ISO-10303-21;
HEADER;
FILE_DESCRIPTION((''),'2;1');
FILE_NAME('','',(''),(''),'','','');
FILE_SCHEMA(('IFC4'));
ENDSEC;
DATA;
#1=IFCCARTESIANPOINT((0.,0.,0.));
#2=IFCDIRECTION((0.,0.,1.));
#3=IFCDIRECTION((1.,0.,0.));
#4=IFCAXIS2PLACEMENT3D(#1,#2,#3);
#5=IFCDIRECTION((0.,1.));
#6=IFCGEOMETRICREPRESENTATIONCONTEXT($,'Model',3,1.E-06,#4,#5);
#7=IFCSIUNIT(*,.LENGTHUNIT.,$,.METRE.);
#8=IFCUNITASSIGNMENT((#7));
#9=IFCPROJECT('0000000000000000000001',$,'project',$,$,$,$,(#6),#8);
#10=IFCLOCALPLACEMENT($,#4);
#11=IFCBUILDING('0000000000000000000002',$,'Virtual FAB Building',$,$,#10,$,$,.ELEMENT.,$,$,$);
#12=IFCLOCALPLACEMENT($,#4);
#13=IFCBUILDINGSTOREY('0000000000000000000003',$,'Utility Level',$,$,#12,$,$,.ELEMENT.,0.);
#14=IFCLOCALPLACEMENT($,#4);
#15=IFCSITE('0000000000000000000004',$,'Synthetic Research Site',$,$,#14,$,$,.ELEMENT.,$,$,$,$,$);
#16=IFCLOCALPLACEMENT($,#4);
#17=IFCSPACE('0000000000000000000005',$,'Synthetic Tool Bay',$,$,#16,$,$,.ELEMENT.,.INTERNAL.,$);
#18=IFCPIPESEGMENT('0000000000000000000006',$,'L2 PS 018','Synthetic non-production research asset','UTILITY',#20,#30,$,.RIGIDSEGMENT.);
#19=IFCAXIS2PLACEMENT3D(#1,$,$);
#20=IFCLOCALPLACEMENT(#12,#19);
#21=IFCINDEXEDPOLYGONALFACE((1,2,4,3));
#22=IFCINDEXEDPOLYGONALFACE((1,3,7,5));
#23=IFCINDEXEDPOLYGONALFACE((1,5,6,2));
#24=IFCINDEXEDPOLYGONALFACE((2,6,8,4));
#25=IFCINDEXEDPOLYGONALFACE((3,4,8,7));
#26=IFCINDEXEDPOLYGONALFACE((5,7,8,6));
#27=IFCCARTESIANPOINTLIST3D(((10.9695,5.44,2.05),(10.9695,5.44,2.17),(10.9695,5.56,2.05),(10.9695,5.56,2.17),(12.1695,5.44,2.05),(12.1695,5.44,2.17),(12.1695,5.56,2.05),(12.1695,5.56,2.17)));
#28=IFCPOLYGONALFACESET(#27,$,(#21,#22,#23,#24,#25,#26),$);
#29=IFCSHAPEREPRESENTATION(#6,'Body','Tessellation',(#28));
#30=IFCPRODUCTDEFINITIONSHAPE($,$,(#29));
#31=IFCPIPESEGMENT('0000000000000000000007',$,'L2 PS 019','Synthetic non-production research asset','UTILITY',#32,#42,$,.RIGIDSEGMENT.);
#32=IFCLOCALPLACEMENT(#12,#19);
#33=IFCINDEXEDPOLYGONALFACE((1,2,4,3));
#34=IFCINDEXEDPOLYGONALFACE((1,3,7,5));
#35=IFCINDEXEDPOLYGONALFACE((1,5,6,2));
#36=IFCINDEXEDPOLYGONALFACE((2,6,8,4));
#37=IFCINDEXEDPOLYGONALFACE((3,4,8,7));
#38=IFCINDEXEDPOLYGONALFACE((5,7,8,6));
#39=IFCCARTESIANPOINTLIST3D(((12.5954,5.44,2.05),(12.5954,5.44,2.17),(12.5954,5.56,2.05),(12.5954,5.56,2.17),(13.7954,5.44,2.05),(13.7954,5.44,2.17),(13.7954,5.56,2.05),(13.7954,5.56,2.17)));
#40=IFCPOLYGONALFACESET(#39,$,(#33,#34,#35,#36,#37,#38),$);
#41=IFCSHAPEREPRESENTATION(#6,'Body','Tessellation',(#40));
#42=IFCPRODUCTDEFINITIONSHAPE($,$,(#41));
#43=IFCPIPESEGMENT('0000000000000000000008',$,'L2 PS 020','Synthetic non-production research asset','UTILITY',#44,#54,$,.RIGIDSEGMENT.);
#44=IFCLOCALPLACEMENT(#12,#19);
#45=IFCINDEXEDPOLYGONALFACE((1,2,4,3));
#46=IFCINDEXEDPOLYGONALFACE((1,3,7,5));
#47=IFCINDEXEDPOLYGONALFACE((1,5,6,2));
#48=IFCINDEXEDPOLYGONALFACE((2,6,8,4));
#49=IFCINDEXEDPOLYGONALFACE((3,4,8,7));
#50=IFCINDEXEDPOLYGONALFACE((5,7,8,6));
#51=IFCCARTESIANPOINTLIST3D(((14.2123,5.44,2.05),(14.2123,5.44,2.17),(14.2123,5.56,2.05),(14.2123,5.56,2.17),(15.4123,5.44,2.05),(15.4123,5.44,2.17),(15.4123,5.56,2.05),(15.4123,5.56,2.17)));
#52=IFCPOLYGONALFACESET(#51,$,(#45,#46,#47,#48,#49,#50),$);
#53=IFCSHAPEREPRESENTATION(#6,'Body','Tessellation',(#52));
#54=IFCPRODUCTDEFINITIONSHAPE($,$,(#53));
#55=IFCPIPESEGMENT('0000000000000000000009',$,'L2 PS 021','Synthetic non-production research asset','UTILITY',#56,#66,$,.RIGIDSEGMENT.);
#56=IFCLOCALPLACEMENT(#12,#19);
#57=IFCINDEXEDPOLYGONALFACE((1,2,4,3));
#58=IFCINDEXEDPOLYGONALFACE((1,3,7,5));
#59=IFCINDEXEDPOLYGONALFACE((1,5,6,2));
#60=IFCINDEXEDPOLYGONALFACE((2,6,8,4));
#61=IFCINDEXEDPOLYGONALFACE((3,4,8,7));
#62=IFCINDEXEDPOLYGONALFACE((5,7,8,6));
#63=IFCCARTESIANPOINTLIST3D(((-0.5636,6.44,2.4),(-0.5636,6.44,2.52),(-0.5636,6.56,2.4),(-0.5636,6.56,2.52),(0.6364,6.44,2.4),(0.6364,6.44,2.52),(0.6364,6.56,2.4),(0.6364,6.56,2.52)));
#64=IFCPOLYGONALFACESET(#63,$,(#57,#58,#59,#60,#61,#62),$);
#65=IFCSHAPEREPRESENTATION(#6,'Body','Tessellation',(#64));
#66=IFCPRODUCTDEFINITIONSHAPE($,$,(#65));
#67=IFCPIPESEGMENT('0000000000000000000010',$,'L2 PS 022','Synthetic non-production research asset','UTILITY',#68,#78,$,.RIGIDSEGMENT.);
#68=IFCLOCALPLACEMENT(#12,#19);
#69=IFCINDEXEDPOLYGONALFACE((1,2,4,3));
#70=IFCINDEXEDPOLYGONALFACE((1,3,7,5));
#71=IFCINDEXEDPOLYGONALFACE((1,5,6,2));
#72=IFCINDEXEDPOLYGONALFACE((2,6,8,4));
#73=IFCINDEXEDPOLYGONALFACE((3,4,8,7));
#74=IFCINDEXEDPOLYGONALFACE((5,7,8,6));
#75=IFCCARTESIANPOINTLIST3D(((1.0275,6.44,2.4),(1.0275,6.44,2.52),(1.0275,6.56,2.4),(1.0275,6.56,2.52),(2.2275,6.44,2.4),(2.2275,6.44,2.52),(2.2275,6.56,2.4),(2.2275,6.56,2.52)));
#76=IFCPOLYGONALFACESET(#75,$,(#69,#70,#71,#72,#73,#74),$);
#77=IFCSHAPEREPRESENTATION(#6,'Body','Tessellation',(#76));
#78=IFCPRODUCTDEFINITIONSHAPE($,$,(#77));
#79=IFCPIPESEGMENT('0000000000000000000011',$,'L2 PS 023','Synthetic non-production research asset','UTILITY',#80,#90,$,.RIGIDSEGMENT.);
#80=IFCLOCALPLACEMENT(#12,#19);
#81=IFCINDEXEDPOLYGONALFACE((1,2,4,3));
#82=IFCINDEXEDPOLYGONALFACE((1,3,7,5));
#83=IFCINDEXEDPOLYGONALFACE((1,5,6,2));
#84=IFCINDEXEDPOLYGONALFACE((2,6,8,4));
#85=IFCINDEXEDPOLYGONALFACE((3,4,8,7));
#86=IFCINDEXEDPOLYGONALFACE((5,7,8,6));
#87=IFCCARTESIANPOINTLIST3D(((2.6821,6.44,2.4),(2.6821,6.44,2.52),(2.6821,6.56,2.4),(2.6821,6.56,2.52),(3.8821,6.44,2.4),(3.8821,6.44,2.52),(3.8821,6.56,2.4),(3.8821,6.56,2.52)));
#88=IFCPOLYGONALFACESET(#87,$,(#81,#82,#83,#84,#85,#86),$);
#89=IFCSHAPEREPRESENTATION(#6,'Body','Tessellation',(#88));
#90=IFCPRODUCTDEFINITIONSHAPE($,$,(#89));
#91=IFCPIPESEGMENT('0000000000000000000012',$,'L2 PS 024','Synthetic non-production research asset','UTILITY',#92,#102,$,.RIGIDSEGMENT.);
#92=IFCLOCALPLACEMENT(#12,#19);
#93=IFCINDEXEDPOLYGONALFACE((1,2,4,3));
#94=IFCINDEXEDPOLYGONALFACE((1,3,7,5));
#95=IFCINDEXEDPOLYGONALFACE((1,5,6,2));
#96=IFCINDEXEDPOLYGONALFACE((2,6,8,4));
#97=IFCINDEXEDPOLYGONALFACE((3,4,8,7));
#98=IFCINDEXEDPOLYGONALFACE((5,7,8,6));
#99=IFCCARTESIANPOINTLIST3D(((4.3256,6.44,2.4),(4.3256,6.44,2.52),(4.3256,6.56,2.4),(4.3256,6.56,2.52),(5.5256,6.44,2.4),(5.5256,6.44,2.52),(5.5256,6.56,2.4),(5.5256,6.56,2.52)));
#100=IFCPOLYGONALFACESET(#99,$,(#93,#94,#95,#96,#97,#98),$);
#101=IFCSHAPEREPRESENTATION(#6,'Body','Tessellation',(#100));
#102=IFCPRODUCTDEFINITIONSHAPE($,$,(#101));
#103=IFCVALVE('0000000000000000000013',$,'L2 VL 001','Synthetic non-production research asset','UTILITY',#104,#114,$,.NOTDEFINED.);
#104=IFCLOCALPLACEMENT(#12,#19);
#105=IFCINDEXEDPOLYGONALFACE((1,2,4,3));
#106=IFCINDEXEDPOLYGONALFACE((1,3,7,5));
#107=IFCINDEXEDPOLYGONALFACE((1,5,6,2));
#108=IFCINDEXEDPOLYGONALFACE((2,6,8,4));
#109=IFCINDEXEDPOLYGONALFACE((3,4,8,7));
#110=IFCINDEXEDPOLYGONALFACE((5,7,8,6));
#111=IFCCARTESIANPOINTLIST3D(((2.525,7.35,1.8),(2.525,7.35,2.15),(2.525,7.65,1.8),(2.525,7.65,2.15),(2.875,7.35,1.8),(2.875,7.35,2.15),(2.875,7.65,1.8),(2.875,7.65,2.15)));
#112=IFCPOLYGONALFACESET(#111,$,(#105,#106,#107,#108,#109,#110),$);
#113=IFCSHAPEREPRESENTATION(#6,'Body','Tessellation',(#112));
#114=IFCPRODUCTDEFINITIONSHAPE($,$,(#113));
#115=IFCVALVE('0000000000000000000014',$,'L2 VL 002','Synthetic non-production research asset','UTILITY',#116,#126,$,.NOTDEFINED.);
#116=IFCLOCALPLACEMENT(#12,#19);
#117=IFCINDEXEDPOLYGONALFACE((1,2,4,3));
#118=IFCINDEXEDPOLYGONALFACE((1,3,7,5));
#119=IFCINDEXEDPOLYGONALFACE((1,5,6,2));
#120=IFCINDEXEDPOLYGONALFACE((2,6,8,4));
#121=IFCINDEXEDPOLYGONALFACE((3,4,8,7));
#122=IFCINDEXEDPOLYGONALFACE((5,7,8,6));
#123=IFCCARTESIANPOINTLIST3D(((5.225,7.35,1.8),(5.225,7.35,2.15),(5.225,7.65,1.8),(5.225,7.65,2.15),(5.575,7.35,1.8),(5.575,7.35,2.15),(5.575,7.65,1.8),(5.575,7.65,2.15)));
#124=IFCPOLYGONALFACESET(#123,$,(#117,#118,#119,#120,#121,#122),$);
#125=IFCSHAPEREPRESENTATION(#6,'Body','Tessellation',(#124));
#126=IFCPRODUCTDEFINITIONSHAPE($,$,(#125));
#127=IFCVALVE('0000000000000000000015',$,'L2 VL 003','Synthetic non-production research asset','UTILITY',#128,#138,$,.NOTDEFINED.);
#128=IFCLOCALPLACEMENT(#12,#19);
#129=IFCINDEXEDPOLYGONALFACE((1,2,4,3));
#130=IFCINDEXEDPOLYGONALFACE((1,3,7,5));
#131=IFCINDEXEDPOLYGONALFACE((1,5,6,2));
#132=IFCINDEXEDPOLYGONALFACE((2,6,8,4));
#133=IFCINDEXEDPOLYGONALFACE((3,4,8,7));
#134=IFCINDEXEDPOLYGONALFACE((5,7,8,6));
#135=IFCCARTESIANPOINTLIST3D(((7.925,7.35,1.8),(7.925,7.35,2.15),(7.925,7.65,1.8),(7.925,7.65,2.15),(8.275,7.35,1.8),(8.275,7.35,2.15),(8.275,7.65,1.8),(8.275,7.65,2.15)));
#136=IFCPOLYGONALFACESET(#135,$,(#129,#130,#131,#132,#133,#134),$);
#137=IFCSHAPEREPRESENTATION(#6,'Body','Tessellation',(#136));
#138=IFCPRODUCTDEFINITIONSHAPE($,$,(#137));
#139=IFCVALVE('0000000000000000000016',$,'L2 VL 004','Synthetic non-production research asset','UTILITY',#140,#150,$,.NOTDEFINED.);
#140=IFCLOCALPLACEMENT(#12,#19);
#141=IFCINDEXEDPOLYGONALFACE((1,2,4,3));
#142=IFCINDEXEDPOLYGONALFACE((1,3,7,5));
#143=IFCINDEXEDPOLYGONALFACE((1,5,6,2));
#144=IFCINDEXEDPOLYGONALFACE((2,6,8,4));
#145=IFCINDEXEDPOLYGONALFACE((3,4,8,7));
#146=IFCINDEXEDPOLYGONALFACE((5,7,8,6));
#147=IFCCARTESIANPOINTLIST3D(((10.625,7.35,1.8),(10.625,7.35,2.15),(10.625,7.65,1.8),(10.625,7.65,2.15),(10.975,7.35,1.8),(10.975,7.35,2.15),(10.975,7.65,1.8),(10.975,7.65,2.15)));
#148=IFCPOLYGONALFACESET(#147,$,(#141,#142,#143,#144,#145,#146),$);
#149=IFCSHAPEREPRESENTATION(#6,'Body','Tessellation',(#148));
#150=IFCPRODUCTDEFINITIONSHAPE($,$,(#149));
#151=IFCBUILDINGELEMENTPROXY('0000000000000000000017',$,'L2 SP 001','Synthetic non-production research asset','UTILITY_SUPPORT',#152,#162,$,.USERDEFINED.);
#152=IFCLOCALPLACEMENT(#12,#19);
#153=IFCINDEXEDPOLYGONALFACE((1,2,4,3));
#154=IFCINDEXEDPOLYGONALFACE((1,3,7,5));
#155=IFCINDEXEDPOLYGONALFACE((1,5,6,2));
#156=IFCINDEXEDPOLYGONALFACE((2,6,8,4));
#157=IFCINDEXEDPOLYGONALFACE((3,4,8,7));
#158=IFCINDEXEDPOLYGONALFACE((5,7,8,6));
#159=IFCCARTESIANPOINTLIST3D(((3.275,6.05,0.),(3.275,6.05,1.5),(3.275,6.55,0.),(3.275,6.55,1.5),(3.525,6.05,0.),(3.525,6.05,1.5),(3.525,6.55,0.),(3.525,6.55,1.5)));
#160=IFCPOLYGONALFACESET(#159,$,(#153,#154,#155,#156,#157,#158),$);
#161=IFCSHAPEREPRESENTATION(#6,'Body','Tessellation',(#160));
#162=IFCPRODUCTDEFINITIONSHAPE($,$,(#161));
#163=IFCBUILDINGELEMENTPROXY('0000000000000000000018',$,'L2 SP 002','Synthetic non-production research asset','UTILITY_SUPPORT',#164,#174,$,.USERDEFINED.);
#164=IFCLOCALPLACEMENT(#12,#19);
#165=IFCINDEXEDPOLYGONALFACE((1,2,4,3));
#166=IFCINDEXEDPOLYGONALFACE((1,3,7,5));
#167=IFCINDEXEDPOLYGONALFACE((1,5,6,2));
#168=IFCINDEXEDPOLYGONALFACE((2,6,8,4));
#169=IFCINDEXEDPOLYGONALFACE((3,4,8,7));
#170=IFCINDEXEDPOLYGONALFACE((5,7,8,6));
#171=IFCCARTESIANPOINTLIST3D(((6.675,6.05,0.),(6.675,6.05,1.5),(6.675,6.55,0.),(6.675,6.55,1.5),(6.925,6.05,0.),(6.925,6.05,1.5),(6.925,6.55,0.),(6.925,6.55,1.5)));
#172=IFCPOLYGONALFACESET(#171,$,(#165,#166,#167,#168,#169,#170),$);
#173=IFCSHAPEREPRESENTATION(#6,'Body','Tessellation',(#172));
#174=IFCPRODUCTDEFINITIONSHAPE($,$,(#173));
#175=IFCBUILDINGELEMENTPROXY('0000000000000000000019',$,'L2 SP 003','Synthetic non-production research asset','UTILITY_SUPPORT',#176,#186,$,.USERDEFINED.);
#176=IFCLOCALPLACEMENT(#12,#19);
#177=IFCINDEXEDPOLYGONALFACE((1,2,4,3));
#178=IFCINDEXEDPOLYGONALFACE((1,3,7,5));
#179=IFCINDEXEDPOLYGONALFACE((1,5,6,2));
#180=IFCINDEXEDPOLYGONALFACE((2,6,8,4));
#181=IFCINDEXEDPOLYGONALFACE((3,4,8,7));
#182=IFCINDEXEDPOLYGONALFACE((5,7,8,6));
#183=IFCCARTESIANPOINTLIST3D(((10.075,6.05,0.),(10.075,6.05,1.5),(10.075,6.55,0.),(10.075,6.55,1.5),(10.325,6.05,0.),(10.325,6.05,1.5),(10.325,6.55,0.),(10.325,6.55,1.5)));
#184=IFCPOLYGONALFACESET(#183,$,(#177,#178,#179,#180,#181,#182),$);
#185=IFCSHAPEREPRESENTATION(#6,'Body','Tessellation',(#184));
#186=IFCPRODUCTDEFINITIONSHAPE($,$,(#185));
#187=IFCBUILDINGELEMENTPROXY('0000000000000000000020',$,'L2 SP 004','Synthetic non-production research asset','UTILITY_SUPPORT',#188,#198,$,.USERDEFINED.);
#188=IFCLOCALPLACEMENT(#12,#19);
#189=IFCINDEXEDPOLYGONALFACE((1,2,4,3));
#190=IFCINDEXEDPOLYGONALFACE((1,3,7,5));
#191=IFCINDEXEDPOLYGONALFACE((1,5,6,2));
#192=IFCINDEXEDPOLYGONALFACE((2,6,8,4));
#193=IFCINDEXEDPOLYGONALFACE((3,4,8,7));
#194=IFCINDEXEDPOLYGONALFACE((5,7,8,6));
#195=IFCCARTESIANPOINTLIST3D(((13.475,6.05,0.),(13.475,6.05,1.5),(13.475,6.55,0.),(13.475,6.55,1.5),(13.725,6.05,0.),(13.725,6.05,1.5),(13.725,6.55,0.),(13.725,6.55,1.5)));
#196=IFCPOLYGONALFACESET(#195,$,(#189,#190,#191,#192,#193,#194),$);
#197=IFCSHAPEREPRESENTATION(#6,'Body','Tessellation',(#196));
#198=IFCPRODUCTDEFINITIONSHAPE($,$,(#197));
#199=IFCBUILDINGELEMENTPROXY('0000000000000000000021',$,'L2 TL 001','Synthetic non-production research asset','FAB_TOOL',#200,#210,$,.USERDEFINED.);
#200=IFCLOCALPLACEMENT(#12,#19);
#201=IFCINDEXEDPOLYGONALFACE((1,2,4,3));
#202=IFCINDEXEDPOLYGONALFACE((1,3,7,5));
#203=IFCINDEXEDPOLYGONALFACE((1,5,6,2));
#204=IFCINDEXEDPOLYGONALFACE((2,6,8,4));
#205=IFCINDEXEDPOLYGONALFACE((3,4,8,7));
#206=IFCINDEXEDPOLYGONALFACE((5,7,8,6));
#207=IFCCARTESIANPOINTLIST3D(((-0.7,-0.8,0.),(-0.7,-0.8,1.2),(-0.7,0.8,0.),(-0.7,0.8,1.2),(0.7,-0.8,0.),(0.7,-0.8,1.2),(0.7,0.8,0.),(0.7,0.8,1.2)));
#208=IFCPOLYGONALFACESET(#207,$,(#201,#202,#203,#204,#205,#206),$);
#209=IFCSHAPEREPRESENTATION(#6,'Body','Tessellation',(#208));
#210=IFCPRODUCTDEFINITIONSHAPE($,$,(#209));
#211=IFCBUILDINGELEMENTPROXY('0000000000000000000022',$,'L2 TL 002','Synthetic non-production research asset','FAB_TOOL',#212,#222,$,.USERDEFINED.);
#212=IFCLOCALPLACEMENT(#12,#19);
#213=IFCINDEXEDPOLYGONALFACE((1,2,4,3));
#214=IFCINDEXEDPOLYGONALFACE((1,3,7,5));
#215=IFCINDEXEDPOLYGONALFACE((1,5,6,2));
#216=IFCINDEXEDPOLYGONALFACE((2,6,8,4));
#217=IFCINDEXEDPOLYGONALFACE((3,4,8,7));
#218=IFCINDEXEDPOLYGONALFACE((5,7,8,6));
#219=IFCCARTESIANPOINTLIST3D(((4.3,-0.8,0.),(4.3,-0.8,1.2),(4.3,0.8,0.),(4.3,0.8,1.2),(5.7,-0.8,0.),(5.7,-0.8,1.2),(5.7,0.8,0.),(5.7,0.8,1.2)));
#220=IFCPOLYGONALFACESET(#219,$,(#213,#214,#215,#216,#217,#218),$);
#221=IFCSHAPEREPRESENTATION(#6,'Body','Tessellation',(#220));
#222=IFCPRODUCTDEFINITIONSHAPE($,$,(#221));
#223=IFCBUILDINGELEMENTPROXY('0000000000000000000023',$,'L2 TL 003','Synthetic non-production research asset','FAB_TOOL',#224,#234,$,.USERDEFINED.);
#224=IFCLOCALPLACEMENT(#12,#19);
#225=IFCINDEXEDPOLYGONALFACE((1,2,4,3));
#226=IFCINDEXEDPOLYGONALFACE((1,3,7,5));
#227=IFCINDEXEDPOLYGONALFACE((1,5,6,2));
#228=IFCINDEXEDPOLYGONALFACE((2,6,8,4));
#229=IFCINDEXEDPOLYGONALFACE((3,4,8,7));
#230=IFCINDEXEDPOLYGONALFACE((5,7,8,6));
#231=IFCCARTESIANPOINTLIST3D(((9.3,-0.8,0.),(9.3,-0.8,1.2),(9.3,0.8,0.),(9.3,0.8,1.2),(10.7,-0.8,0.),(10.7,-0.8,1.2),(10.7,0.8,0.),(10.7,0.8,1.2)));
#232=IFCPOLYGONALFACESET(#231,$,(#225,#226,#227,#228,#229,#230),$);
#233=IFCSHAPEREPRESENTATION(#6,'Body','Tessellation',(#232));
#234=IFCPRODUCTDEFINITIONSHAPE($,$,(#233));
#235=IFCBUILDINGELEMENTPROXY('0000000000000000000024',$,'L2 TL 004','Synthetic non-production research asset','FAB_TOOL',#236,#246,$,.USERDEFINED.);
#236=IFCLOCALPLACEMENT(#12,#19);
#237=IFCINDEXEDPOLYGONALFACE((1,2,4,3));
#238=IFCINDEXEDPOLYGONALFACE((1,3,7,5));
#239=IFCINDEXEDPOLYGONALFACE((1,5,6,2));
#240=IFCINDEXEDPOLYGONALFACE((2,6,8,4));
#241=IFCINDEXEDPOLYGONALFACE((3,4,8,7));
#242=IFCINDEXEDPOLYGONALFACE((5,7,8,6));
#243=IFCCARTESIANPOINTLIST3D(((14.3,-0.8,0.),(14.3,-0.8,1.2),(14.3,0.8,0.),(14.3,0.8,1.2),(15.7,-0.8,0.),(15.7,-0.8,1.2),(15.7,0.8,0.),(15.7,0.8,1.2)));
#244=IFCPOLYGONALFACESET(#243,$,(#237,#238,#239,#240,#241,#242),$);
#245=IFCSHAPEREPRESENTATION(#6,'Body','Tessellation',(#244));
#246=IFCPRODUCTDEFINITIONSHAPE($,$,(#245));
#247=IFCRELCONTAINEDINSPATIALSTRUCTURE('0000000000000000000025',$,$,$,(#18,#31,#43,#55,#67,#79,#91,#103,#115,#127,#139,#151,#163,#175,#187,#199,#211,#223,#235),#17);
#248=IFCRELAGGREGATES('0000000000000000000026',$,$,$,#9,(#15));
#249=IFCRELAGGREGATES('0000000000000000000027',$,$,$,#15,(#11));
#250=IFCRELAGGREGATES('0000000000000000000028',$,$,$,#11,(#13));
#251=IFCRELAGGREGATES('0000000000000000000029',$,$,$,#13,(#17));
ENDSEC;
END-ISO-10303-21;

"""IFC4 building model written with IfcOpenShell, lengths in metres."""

from ifc_helpers import new_model, si_unit, direction, frame, origin_with_axes, origin_2d_with_axis, place, context, project, spatial, rectangle, extrude, element, save


model = new_model("IFC4")

# Units and contexts
model_context = context("Model", 3, precision=1e-06, world=origin_with_axes(), true_north=direction((0.0, 1.0)))
ifc_project = project(units=[si_unit("LENGTHUNIT", "METRE")], contexts=[model_context])

# Site, building, storey, space
site_placement = place(None, origin_with_axes())
site = spatial("IfcSite", under=ifc_project, at=site_placement, Name="Synthetic Research Site", CompositionType="ELEMENT")
building_placement = place(None, origin_with_axes())
building = spatial("IfcBuilding", under=site, at=building_placement, Name="Virtual FAB Building", CompositionType="ELEMENT")
storey_placement = place(None, origin_with_axes())
storey = spatial("IfcBuildingStorey", under=building, at=storey_placement, Name="Utility Level", CompositionType="ELEMENT", Elevation=0.0)
space_placement = place(None, origin_with_axes())
space = spatial("IfcSpace", under=storey, at=space_placement, Name="Synthetic Tool Bay", CompositionType="ELEMENT", PredefinedType="INTERNAL")

# Pipe segments
for number, where, z_axis, x_axis, name in (
    (1, (11.5695, 5.5, 2.05), (0.0, 0.0, 1.0), (1.0, 0.0, 0.0), "L2 PS 018"),
    (2, (13.1954, 5.5, 2.05), (0.0, 0.0, 1.0), (1.0, 0.0, 0.0), "L2 PS 019"),
    (3, (14.8123, 5.5, 2.05), (0.0, 0.0, 1.0), (1.0, 0.0, 0.0), "L2 PS 020"),
    (4, (0.0364, 6.5, 2.4), (0.0, 0.0, 1.0), (1.0, 0.0, 0.0), "L2 PS 021"),
    (5, (1.6275, 6.5, 2.4), (0.0, 0.0, 1.0), (1.0, 0.0, 0.0), "L2 PS 022"),
    (6, (3.2821, 6.5, 2.4), (0.0, 0.0, 1.0), (1.0, 0.0, 0.0), "L2 PS 023"),
    (7, (4.9256, 6.5, 2.4), (0.0, 0.0, 1.0), (1.0, 0.0, 0.0), "L2 PS 024"),
):
    element("IfcPipeSegment", number, at=place(None, frame(where, z_axis=z_axis, x_axis=x_axis)), inside=space, Name=name, Description="Synthetic non-production research asset", ObjectType="UTILITY", PredefinedType="RIGIDSEGMENT", context=model_context, shape_type="SweptSolid", body=[
        extrude(rectangle(XDim=1.2, YDim=0.12, at=origin_2d_with_axis()), origin_with_axes(), (0.0, 0.0, 1.0), 0.12),
    ])

# Valves
for number, where, z_axis, x_axis, name in (
    (8, (2.7, 7.5, 1.8), (0.0, 0.0, 1.0), (1.0, 0.0, 0.0), "L2 VL 001"),
    (9, (5.4, 7.5, 1.8), (0.0, 0.0, 1.0), (1.0, 0.0, 0.0), "L2 VL 002"),
    (10, (8.1, 7.5, 1.8), (0.0, 0.0, 1.0), (1.0, 0.0, 0.0), "L2 VL 003"),
    (11, (10.8, 7.5, 1.8), (0.0, 0.0, 1.0), (1.0, 0.0, 0.0), "L2 VL 004"),
):
    element("IfcValve", number, at=place(None, frame(where, z_axis=z_axis, x_axis=x_axis)), inside=space, Name=name, Description="Synthetic non-production research asset", ObjectType="UTILITY", PredefinedType="NOTDEFINED", context=model_context, shape_type="SweptSolid", body=[
        extrude(rectangle(XDim=0.35, YDim=0.3, at=origin_2d_with_axis()), origin_with_axes(), (0.0, 0.0, 1.0), 0.35),
    ])

# Building element proxies
for number, where, z_axis, x_axis, name in (
    (12, (3.4, 6.3, 0.0), (0.0, 0.0, 1.0), (1.0, 0.0, 0.0), "L2 SP 001"),
    (13, (6.8, 6.3, 0.0), (0.0, 0.0, 1.0), (1.0, 0.0, 0.0), "L2 SP 002"),
    (14, (10.2, 6.3, 0.0), (0.0, 0.0, 1.0), (1.0, 0.0, 0.0), "L2 SP 003"),
    (15, (13.6, 6.3, 0.0), (0.0, 0.0, 1.0), (1.0, 0.0, 0.0), "L2 SP 004"),
):
    element("IfcBuildingElementProxy", number, at=place(None, frame(where, z_axis=z_axis, x_axis=x_axis)), inside=space, Name=name, Description="Synthetic non-production research asset", ObjectType="UTILITY_SUPPORT", PredefinedType="USERDEFINED", context=model_context, shape_type="SweptSolid", body=[
        extrude(rectangle(XDim=0.25, YDim=0.5, at=origin_2d_with_axis()), origin_with_axes(), (0.0, 0.0, 1.0), 1.5),
    ])
for number, where, z_axis, x_axis, name in (
    (16, (0.0, 0.0, 0.0), (0.0, 0.0, 1.0), (1.0, 0.0, 0.0), "L2 TL 001"),
    (17, (5.0, 0.0, 0.0), (0.0, 0.0, 1.0), (1.0, 0.0, 0.0), "L2 TL 002"),
    (18, (10.0, 0.0, 0.0), (0.0, 0.0, 1.0), (1.0, 0.0, 0.0), "L2 TL 003"),
    (19, (15.0, 0.0, 0.0), (0.0, 0.0, 1.0), (1.0, 0.0, 0.0), "L2 TL 004"),
):
    element("IfcBuildingElementProxy", number, at=place(None, frame(where, z_axis=z_axis, x_axis=x_axis)), inside=space, Name=name, Description="Synthetic non-production research asset", ObjectType="FAB_TOOL", PredefinedType="USERDEFINED", context=model_context, shape_type="SweptSolid", body=[
        extrude(rectangle(XDim=1.4, YDim=1.6, at=origin_2d_with_axis()), origin_with_axes(), (0.0, 0.0, 1.0), 1.2),
    ])

save(model, "model.ifc")
